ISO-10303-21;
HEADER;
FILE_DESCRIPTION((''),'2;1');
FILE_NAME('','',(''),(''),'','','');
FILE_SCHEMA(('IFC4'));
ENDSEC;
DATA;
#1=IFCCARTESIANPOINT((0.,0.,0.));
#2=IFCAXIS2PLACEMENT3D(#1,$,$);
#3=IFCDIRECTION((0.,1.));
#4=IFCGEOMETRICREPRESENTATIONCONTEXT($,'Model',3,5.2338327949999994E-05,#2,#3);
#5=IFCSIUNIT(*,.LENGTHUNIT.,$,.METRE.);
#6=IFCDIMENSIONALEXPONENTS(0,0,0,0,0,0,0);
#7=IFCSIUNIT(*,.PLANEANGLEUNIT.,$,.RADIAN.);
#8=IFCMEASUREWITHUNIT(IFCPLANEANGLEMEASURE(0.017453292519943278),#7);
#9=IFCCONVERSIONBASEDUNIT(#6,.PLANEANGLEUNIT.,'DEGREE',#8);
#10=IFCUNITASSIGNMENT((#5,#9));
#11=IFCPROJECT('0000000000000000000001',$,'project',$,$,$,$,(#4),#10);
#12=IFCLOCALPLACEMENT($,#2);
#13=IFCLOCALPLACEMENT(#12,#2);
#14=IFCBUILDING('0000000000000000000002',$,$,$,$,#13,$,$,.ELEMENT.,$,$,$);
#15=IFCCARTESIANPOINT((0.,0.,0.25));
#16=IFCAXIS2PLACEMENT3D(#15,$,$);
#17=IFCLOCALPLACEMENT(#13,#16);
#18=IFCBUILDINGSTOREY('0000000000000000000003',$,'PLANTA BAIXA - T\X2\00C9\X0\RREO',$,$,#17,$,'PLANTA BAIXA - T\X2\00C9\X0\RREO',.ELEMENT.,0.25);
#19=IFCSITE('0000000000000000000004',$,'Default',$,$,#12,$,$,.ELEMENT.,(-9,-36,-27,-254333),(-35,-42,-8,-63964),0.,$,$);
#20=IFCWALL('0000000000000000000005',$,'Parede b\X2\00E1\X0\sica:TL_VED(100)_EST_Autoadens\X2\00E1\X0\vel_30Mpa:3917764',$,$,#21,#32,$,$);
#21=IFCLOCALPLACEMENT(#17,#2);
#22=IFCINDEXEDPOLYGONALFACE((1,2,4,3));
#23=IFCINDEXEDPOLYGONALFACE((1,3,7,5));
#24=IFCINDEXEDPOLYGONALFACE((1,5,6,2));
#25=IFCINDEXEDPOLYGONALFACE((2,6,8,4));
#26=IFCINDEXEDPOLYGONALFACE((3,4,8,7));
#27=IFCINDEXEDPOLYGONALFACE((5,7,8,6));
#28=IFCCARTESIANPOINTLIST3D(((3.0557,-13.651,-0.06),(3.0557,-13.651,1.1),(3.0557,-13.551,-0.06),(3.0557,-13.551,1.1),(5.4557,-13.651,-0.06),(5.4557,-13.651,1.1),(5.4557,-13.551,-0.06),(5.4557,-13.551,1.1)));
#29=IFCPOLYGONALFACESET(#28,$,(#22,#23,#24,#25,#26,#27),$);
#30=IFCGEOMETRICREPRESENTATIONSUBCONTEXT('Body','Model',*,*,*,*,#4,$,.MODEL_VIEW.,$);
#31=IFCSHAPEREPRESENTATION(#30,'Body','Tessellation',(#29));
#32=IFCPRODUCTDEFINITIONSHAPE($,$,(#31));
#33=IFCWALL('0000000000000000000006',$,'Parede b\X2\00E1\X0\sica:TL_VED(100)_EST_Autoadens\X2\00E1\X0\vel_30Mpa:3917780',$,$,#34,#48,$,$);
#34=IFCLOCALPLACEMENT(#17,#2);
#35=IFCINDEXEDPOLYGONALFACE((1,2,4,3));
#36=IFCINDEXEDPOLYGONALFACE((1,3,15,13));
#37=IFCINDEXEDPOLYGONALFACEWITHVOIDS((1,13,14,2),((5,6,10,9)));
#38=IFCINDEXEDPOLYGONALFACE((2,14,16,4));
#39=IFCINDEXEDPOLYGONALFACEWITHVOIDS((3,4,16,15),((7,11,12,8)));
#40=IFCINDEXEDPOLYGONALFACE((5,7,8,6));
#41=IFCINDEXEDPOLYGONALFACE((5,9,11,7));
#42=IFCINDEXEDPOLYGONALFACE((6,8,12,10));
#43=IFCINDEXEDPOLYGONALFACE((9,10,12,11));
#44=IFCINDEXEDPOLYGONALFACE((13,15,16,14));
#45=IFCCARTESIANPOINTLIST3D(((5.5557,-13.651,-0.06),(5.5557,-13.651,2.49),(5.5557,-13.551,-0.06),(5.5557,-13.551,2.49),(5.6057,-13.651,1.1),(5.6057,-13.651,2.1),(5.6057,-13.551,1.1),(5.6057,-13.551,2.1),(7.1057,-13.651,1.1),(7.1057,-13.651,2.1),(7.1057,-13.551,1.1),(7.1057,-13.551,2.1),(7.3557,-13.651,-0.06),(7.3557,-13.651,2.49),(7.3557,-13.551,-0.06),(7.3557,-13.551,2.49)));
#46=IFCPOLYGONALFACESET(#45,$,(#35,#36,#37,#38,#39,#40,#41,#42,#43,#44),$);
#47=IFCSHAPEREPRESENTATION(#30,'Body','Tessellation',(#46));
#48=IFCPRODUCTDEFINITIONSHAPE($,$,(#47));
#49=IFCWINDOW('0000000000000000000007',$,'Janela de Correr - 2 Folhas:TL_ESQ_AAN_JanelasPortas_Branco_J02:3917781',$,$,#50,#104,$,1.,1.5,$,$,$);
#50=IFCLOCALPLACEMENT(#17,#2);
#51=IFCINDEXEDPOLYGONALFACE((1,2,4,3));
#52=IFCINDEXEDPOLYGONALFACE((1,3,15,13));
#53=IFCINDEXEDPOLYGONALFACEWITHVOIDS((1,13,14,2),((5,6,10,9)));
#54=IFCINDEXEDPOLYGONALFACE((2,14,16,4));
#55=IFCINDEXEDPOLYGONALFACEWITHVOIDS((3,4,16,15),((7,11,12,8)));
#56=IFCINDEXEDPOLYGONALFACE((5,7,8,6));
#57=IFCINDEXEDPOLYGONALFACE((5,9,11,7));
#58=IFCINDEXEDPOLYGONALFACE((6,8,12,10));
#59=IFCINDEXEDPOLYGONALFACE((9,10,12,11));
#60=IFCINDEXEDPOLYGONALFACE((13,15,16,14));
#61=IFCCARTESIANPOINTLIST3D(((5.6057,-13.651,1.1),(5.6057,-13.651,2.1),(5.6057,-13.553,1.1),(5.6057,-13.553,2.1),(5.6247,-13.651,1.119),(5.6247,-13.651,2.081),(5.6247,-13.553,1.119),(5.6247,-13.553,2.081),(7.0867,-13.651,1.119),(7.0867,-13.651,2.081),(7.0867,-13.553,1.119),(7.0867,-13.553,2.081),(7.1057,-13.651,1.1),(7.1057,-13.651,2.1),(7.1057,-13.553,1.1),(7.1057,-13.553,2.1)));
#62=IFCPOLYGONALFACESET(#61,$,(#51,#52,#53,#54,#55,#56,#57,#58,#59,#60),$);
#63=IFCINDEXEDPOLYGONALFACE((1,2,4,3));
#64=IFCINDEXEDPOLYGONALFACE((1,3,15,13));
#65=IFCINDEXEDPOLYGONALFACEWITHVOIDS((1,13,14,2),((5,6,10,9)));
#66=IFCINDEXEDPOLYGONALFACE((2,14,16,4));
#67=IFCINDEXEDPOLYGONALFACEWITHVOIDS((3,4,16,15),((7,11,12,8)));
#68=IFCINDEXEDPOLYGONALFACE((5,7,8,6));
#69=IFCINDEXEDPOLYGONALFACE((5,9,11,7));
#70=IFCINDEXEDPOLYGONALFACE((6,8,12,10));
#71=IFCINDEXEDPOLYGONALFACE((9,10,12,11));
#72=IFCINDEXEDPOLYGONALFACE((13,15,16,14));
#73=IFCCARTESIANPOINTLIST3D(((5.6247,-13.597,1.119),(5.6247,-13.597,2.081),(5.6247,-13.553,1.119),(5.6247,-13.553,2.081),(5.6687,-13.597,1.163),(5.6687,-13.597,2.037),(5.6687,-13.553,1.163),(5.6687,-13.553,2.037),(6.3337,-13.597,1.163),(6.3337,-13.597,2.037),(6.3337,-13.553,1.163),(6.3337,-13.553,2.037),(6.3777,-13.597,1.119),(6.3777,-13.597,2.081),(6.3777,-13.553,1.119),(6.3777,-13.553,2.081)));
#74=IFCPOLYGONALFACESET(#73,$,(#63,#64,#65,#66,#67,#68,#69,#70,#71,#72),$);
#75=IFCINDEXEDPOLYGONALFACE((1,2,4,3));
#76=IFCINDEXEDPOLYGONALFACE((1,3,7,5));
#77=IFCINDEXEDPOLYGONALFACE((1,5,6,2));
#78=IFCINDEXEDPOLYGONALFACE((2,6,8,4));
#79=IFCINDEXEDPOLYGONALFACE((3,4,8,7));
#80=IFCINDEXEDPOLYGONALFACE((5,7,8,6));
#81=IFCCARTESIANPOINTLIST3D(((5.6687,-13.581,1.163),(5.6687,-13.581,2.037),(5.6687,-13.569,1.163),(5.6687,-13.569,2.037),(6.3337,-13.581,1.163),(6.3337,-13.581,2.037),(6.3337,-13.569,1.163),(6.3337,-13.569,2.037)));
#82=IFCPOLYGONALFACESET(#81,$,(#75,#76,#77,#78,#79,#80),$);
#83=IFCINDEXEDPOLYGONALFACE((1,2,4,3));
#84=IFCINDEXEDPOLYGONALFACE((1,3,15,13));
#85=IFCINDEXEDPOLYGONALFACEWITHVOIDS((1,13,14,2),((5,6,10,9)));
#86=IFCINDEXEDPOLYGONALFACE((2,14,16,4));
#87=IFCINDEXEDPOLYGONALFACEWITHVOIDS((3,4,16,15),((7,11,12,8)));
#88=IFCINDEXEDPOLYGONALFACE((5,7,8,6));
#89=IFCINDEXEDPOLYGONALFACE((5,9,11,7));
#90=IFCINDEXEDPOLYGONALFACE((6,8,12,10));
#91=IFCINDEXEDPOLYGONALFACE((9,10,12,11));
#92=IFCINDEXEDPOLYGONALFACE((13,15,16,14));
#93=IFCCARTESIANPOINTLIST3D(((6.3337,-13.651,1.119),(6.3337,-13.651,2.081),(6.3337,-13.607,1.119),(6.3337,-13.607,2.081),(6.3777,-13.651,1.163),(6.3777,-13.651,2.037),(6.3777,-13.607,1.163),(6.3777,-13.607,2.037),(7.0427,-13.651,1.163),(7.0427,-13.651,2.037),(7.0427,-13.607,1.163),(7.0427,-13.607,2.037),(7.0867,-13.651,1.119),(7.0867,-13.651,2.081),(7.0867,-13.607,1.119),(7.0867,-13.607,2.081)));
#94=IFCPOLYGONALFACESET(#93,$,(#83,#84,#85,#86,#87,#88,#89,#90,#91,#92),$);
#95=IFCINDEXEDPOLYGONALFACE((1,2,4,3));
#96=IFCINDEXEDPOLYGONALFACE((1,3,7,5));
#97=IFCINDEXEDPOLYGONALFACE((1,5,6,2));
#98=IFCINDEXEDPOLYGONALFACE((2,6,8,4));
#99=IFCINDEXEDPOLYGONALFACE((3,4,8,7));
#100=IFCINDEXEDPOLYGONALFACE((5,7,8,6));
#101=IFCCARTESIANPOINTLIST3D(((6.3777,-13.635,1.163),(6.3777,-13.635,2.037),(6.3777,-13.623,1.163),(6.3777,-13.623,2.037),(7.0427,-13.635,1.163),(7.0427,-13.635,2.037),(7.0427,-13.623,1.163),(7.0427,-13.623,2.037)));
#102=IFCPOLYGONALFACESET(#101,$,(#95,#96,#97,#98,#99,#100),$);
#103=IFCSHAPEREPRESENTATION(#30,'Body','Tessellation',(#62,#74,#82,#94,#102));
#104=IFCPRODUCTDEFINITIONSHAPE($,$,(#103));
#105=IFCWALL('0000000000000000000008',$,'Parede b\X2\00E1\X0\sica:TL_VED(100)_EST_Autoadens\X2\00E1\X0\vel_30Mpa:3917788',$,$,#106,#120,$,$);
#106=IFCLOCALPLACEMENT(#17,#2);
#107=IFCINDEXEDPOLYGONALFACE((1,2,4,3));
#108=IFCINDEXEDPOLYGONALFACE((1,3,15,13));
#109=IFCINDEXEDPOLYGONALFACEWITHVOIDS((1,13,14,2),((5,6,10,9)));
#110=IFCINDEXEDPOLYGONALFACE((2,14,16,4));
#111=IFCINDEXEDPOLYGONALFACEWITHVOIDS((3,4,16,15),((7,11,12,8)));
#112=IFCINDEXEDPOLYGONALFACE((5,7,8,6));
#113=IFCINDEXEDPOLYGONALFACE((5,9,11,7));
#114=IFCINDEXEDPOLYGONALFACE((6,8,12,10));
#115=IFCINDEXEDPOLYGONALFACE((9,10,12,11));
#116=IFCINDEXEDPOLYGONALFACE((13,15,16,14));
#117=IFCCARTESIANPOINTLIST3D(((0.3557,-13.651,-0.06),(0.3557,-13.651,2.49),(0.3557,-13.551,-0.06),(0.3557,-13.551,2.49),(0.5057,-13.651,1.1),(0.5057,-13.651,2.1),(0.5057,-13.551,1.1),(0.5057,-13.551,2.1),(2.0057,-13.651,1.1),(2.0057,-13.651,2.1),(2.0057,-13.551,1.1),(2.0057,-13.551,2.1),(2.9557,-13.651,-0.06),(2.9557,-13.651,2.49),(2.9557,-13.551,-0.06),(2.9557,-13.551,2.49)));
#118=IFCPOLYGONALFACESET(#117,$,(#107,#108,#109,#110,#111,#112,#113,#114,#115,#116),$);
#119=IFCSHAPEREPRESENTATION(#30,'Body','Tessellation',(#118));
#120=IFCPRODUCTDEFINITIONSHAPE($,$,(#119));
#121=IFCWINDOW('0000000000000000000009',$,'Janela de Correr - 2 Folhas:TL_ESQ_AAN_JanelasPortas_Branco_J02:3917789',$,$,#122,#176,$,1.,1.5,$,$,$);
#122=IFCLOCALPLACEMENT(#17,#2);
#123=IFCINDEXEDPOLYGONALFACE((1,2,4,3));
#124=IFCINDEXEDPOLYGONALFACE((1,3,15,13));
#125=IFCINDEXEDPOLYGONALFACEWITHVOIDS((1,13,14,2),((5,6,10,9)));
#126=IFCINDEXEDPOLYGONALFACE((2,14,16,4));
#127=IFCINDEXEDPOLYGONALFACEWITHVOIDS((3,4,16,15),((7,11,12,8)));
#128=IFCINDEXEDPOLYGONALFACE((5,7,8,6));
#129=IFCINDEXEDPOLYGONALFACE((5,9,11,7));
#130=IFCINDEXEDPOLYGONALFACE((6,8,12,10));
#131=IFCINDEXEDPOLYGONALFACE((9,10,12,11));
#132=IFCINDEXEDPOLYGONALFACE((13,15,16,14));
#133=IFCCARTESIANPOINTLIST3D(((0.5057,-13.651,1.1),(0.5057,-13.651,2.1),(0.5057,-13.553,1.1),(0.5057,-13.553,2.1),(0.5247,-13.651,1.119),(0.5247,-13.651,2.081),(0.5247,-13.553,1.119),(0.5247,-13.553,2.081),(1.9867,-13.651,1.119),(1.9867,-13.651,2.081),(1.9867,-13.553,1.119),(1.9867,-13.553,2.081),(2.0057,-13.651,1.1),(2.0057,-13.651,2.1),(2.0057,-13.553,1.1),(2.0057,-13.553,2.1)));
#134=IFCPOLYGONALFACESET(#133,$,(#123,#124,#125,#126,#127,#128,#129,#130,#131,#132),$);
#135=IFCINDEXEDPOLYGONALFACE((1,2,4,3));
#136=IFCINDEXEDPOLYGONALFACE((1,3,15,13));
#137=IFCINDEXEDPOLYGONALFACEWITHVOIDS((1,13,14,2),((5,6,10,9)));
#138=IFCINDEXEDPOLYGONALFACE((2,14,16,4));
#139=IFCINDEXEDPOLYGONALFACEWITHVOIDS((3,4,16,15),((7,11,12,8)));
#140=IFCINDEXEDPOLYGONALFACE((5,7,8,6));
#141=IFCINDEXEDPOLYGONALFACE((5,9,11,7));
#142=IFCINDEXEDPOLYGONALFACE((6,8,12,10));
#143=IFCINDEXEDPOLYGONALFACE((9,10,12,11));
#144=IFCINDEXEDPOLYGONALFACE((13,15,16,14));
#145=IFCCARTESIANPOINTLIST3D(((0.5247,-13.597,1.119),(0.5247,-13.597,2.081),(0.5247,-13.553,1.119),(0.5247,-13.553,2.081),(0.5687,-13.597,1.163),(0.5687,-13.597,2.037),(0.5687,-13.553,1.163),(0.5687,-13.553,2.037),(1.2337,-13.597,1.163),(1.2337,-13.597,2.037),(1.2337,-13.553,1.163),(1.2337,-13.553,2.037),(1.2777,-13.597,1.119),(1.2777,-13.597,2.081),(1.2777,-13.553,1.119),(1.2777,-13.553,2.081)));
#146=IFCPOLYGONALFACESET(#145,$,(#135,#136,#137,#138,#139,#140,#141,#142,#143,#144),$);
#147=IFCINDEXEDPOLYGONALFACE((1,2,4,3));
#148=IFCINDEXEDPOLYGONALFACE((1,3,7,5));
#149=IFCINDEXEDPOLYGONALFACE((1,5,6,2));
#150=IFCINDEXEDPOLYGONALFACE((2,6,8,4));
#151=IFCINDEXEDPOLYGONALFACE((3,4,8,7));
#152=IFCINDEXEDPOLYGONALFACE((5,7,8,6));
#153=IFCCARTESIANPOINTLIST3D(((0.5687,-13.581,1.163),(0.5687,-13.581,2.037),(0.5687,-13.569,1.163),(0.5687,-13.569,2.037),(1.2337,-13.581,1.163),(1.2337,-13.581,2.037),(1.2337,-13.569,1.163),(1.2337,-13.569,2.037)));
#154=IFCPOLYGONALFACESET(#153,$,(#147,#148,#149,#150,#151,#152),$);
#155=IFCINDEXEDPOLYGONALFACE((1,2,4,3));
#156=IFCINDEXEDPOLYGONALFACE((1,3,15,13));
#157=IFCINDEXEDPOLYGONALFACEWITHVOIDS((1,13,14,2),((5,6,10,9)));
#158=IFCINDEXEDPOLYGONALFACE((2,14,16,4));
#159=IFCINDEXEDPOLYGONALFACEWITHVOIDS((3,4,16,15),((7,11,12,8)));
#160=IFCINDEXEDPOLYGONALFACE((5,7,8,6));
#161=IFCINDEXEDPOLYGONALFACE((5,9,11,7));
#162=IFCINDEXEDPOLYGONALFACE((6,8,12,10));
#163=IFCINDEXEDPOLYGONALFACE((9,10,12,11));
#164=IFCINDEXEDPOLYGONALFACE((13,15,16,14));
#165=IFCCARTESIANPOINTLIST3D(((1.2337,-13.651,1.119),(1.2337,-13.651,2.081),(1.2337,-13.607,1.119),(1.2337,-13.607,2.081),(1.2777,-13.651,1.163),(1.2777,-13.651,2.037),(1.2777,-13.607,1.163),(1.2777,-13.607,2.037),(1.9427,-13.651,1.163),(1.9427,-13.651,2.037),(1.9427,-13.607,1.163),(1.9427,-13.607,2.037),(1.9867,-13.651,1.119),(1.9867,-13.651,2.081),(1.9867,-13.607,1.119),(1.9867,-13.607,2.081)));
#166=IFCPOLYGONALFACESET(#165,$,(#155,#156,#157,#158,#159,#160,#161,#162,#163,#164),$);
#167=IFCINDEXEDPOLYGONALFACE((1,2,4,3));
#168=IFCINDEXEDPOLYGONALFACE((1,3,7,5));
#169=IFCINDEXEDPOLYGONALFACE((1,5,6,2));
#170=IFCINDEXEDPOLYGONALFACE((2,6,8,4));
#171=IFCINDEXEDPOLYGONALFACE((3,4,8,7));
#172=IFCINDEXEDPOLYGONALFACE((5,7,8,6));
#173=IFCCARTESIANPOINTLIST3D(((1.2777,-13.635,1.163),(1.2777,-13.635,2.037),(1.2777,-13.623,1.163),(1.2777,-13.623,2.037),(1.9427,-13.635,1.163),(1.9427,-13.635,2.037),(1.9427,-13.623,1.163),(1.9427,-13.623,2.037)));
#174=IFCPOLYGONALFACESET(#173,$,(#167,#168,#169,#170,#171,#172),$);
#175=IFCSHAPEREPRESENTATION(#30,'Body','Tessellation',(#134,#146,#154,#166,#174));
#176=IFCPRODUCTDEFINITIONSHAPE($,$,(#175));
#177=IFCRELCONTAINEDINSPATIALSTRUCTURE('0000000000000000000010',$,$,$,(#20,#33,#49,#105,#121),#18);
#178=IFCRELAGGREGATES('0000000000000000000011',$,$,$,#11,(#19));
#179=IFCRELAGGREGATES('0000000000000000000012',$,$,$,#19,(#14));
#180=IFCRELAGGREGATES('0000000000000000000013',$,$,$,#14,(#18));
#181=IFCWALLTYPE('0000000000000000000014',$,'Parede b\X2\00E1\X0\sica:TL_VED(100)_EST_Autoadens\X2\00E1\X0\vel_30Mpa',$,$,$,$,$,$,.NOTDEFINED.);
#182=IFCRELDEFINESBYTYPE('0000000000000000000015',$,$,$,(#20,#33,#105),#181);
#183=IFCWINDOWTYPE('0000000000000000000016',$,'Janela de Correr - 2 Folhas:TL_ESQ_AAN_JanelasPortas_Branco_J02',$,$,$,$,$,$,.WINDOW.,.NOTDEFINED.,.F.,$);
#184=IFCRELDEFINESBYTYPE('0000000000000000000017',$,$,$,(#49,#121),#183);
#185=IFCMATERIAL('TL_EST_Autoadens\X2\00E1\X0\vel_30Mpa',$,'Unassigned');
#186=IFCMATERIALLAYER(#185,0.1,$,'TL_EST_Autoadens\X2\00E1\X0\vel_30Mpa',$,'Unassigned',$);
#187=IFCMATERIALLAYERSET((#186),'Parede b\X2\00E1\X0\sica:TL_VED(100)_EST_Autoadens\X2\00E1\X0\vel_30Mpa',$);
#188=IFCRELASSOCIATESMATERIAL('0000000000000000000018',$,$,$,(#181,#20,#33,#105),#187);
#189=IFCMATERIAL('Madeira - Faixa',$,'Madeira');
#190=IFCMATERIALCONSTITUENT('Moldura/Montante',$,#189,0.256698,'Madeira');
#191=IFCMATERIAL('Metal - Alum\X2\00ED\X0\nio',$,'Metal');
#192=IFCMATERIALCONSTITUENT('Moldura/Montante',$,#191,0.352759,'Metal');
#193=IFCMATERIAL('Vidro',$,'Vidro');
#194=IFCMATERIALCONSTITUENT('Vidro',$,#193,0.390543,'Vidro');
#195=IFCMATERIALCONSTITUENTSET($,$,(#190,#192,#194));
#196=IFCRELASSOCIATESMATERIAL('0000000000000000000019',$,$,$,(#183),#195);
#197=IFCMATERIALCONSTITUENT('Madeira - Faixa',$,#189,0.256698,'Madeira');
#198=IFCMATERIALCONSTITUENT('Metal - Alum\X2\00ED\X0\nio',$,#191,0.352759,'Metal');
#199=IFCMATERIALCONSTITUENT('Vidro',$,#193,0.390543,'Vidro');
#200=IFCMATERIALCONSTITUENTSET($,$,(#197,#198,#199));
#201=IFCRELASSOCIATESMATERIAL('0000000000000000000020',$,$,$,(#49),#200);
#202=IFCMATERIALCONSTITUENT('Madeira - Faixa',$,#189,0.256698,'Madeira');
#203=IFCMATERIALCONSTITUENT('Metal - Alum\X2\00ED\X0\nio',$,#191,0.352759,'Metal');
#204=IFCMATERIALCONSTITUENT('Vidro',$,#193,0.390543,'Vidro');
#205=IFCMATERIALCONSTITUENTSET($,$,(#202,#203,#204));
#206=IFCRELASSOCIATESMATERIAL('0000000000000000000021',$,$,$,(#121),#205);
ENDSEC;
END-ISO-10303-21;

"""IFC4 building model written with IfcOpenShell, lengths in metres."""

from ifc_helpers import new_model, entity, si_unit, converted_unit, direction, frame, frame_2d, origin, origin_2d_with_axis, place, context, subcontext, project, spatial, polyline, rectangle, outline, extrude, source, transform, mapped, material, layer, layer_set, layer_usage, constituent, constituent_set, type_object, type_shapes, element, fill, save


model = new_model("IFC4")

# Units and contexts
model_context = context("Model", 3, precision=5.2338327949999994e-05, world=origin(), true_north=direction((0.0, 1.0)))
body_context = subcontext(model_context, "Body", "Model", "MODEL_VIEW")
ifc_project = project(units=[si_unit("LENGTHUNIT", "METRE"), converted_unit("PLANEANGLEUNIT", "DEGREE", entity("IfcPlaneAngleMeasure", 0.017453292519943278), si_unit("PLANEANGLEUNIT", "RADIAN"), dimensions=[0, 0, 0, 0, 0, 0, 0])], contexts=[model_context])

# Site, building, storey
site_placement = place(None, frame((0.0, 0.0, 0.0)))
site = spatial("IfcSite", under=ifc_project, at=site_placement, Name="Default", CompositionType="ELEMENT", RefLatitude=(-9, -36, -27, -254333), RefLongitude=(-35, -42, -8, -63964), RefElevation=0.0)
building_placement = place(site_placement, origin())
building = spatial("IfcBuilding", under=site, at=building_placement, CompositionType="ELEMENT")
storey_placement = place(building_placement, frame((0.0, 0.0, 0.25)))
storey = spatial("IfcBuildingStorey", under=building, at=storey_placement, Name="PLANTA BAIXA - TÉRREO", LongName="PLANTA BAIXA - TÉRREO", CompositionType="ELEMENT", Elevation=0.25)

# Wall
ifc_material_1 = material(Name="TL_EST_Autoadensável_30Mpa", Category="Unassigned")
ifc_layer_1 = layer(ifc_material_1, 0.1, Name="TL_EST_Autoadensável_30Mpa", Category="Unassigned")
ifc_layer_set_1 = layer_set([ifc_layer_1], Name="Parede básica:TL_VED(100)_EST_Autoadensável_30Mpa")
ifc_layer_usage_1 = layer_usage(ifc_layer_set_1, "AXIS2", "NEGATIVE", 0.05)
wall_type_1 = type_object("IfcWallType", Name="Parede básica:TL_VED(100)_EST_Autoadensável_30Mpa", PredefinedType="NOTDEFINED", material=ifc_layer_set_1)
wall_1_placement = place(storey_placement, frame((3.0557, -13.601, -0.06)))
element("IfcWall", 1, at=wall_1_placement, inside=storey, type_object=wall_type_1, material=ifc_layer_usage_1, Name="Parede básica:TL_VED(100)_EST_Autoadensável_30Mpa:3917764", context=body_context, shape_type="SweptSolid", body=[
    extrude(rectangle(XDim=2.4, YDim=0.1, at=frame_2d((1.2, 0.0), x_axis=(-1.0, 0.0))), origin(), (0.0, 0.0, 1.0), 1.16),
])

# Walls, openings, windows
ifc_layer_usage_2 = layer_usage(ifc_layer_set_1, "AXIS2", "NEGATIVE", 0.05)
wall_2_placement = place(storey_placement, frame((5.5557, -13.601, -0.06)))
wall_2 = element("IfcWall", 2, at=wall_2_placement, inside=storey, type_object=wall_type_1, material=ifc_layer_usage_2, Name="Parede básica:TL_VED(100)_EST_Autoadensável_30Mpa:3917780", context=body_context, shape_type="SweptSolid", body=[
    extrude(rectangle(XDim=1.8, YDim=0.1, at=frame_2d((0.9, 0.0), x_axis=(-1.0, 0.0))), origin(), (0.0, 0.0, 1.0), 2.55),
])
opening_1_placement = place(wall_2_placement, frame((0.05, -0.05, 1.16)))
opening_1 = element("IfcOpeningElement", 3, at=opening_1_placement, cuts=wall_2, PredefinedType="OPENING", context=body_context, shape_type="SweptSolid", body=[
    extrude(rectangle(XDim=1.0, YDim=1.5, at=frame_2d((0.5, 0.75), x_axis=(-1.0, 0.0))), frame((0.0, 0.0, 0.0), z_axis=(0.0, 1.0, 0.0), x_axis=(0.0, 0.0, 1.0)), (0.0, 0.0, 1.0), 0.1),
])
ifc_material_2 = material(Name="Madeira - Faixa", Category="Madeira")
ifc_constituent_1 = constituent(ifc_material_2, Name="Madeira - Faixa", Category="Madeira", fraction=0.256698)
ifc_material_3 = material(Name="Metal - Alumínio", Category="Metal")
ifc_constituent_2 = constituent(ifc_material_3, Name="Metal - Alumínio", Category="Metal", fraction=0.352759)
ifc_material_4 = material(Name="Vidro", Category="Vidro")
ifc_constituent_3 = constituent(ifc_material_4, Name="Vidro", Category="Vidro", fraction=0.390543)
ifc_constituent_set_1 = constituent_set(constituents=[ifc_constituent_1, ifc_constituent_2, ifc_constituent_3])
ifc_constituent_4 = constituent(ifc_material_2, Name="Moldura/Montante", Category="Madeira", fraction=0.256698)
ifc_constituent_5 = constituent(ifc_material_3, Name="Moldura/Montante", Category="Metal", fraction=0.352759)
ifc_constituent_6 = constituent(ifc_material_4, Name="Vidro", Category="Vidro", fraction=0.390543)
ifc_constituent_set_2 = constituent_set(constituents=[ifc_constituent_4, ifc_constituent_5, ifc_constituent_6])
window_type = type_object("IfcWindowType", Name="Janela de Correr - 2 Folhas:TL_ESQ_AAN_JanelasPortas_Branco_J02", ParameterTakesPrecedence=False, PartitioningType="NOTDEFINED", PredefinedType="WINDOW", material=ifc_constituent_set_2)
shared_shape_1 = source(origin(), body_context, "Body", "SweptSolid", [
    extrude(outline(polyline([(-0.75, -0.5), (0.75, -0.5), (0.75, 0.5), (-0.75, 0.5), (-0.75, -0.5)]), holes=[polyline([(-0.731, -0.481), (-0.731, 0.481), (0.731, 0.481), (0.731, -0.481), (-0.731, -0.481)])]), frame((0.75, 0.124, 0.5), z_axis=(0.0, -1.0, 0.0), x_axis=(-1.0, 0.0, 0.0)), (0.0, 0.0, 1.0), 0.098),
    extrude(outline(polyline([(-0.3765, -0.481), (0.3765, -0.481), (0.3765, 0.481), (-0.3765, 0.481), (-0.3765, -0.481)]), holes=[polyline([(-0.3325, -0.437), (-0.3325, 0.437), (0.3325, 0.437), (0.3325, -0.437), (-0.3325, -0.437)])]), frame((0.3955, 0.124, 0.5), z_axis=(0.0, -1.0, 0.0), x_axis=(-1.0, 0.0, 0.0)), (0.0, 0.0, 1.0), 0.044),
    extrude(rectangle(XDim=0.665, YDim=0.012, at=origin_2d_with_axis()), frame((0.3955, 0.102, 0.063), z_axis=(0.0, 0.0, 1.0), x_axis=(-1.0, 0.0, 0.0)), (0.0, 0.0, 1.0), 0.874),
    extrude(outline(polyline([(-0.481, -0.3765), (0.481, -0.3765), (0.481, 0.3765), (-0.481, 0.3765), (-0.481, -0.3765)]), holes=[polyline([(-0.437, -0.3325), (-0.437, 0.3325), (0.437, 0.3325), (0.437, -0.3325), (-0.437, -0.3325)])]), frame((1.1045, 0.07, 0.5), z_axis=(0.0, -1.0, 0.0), x_axis=(0.0, 0.0, -1.0)), (0.0, 0.0, 1.0), 0.044),
    extrude(rectangle(XDim=0.665, YDim=0.012, at=origin_2d_with_axis()), frame((1.1045, 0.048, 0.063), z_axis=(0.0, 0.0, 1.0), x_axis=(-1.0, 0.0, 0.0)), (0.0, 0.0, 1.0), 0.874),
])
type_shapes(window_type, [shared_shape_1])
window_1_placement = place(opening_1_placement, frame((0.0, -0.026, 0.0)))
window_1 = element("IfcWindow", 4, at=window_1_placement, inside=storey, type_object=window_type, material=ifc_constituent_set_1, Name="Janela de Correr - 2 Folhas:TL_ESQ_AAN_JanelasPortas_Branco_J02:3917781", OverallHeight=1.0, OverallWidth=1.5, context=body_context, shape_type="MappedRepresentation", body=[
    mapped(shared_shape_1, transform((0.0, 0.0, 0.0), scale=1.0)),
])
fill(opening_1, window_1)
ifc_layer_usage_3 = layer_usage(ifc_layer_set_1, "AXIS2", "NEGATIVE", 0.05)
wall_3_placement = place(storey_placement, frame((0.3557, -13.601, -0.06)))
wall_3 = element("IfcWall", 5, at=wall_3_placement, inside=storey, type_object=wall_type_1, material=ifc_layer_usage_3, Name="Parede básica:TL_VED(100)_EST_Autoadensável_30Mpa:3917788", context=body_context, shape_type="SweptSolid", body=[
    extrude(rectangle(XDim=2.6, YDim=0.1, at=frame_2d((1.3, 0.0), x_axis=(-1.0, 0.0))), origin(), (0.0, 0.0, 1.0), 2.55),
])
opening_2_placement = place(wall_3_placement, frame((0.15, -0.05, 1.16)))
opening_2 = element("IfcOpeningElement", 6, at=opening_2_placement, cuts=wall_3, PredefinedType="OPENING", context=body_context, shape_type="SweptSolid", body=[
    extrude(rectangle(XDim=1.0, YDim=1.5, at=frame_2d((0.5, 0.75), x_axis=(-1.0, 0.0))), frame((0.0, 0.0, 0.0), z_axis=(0.0, 1.0, 0.0), x_axis=(0.0, 0.0, 1.0)), (0.0, 0.0, 1.0), 0.1),
])
ifc_constituent_7 = constituent(ifc_material_2, Name="Madeira - Faixa", Category="Madeira", fraction=0.256698)
ifc_constituent_8 = constituent(ifc_material_3, Name="Metal - Alumínio", Category="Metal", fraction=0.352759)
ifc_constituent_9 = constituent(ifc_material_4, Name="Vidro", Category="Vidro", fraction=0.390543)
ifc_constituent_set_3 = constituent_set(constituents=[ifc_constituent_7, ifc_constituent_8, ifc_constituent_9])
window_2_placement = place(opening_2_placement, frame((0.0, -0.026, 0.0)))
window_2 = element("IfcWindow", 7, at=window_2_placement, inside=storey, type_object=window_type, material=ifc_constituent_set_3, Name="Janela de Correr - 2 Folhas:TL_ESQ_AAN_JanelasPortas_Branco_J02:3917789", OverallHeight=1.0, OverallWidth=1.5, context=body_context, shape_type="MappedRepresentation", body=[
    mapped(shared_shape_1, transform((0.0, 0.0, 0.0), scale=1.0)),
])
fill(opening_2, window_2)

save(model, "model.ifc")
